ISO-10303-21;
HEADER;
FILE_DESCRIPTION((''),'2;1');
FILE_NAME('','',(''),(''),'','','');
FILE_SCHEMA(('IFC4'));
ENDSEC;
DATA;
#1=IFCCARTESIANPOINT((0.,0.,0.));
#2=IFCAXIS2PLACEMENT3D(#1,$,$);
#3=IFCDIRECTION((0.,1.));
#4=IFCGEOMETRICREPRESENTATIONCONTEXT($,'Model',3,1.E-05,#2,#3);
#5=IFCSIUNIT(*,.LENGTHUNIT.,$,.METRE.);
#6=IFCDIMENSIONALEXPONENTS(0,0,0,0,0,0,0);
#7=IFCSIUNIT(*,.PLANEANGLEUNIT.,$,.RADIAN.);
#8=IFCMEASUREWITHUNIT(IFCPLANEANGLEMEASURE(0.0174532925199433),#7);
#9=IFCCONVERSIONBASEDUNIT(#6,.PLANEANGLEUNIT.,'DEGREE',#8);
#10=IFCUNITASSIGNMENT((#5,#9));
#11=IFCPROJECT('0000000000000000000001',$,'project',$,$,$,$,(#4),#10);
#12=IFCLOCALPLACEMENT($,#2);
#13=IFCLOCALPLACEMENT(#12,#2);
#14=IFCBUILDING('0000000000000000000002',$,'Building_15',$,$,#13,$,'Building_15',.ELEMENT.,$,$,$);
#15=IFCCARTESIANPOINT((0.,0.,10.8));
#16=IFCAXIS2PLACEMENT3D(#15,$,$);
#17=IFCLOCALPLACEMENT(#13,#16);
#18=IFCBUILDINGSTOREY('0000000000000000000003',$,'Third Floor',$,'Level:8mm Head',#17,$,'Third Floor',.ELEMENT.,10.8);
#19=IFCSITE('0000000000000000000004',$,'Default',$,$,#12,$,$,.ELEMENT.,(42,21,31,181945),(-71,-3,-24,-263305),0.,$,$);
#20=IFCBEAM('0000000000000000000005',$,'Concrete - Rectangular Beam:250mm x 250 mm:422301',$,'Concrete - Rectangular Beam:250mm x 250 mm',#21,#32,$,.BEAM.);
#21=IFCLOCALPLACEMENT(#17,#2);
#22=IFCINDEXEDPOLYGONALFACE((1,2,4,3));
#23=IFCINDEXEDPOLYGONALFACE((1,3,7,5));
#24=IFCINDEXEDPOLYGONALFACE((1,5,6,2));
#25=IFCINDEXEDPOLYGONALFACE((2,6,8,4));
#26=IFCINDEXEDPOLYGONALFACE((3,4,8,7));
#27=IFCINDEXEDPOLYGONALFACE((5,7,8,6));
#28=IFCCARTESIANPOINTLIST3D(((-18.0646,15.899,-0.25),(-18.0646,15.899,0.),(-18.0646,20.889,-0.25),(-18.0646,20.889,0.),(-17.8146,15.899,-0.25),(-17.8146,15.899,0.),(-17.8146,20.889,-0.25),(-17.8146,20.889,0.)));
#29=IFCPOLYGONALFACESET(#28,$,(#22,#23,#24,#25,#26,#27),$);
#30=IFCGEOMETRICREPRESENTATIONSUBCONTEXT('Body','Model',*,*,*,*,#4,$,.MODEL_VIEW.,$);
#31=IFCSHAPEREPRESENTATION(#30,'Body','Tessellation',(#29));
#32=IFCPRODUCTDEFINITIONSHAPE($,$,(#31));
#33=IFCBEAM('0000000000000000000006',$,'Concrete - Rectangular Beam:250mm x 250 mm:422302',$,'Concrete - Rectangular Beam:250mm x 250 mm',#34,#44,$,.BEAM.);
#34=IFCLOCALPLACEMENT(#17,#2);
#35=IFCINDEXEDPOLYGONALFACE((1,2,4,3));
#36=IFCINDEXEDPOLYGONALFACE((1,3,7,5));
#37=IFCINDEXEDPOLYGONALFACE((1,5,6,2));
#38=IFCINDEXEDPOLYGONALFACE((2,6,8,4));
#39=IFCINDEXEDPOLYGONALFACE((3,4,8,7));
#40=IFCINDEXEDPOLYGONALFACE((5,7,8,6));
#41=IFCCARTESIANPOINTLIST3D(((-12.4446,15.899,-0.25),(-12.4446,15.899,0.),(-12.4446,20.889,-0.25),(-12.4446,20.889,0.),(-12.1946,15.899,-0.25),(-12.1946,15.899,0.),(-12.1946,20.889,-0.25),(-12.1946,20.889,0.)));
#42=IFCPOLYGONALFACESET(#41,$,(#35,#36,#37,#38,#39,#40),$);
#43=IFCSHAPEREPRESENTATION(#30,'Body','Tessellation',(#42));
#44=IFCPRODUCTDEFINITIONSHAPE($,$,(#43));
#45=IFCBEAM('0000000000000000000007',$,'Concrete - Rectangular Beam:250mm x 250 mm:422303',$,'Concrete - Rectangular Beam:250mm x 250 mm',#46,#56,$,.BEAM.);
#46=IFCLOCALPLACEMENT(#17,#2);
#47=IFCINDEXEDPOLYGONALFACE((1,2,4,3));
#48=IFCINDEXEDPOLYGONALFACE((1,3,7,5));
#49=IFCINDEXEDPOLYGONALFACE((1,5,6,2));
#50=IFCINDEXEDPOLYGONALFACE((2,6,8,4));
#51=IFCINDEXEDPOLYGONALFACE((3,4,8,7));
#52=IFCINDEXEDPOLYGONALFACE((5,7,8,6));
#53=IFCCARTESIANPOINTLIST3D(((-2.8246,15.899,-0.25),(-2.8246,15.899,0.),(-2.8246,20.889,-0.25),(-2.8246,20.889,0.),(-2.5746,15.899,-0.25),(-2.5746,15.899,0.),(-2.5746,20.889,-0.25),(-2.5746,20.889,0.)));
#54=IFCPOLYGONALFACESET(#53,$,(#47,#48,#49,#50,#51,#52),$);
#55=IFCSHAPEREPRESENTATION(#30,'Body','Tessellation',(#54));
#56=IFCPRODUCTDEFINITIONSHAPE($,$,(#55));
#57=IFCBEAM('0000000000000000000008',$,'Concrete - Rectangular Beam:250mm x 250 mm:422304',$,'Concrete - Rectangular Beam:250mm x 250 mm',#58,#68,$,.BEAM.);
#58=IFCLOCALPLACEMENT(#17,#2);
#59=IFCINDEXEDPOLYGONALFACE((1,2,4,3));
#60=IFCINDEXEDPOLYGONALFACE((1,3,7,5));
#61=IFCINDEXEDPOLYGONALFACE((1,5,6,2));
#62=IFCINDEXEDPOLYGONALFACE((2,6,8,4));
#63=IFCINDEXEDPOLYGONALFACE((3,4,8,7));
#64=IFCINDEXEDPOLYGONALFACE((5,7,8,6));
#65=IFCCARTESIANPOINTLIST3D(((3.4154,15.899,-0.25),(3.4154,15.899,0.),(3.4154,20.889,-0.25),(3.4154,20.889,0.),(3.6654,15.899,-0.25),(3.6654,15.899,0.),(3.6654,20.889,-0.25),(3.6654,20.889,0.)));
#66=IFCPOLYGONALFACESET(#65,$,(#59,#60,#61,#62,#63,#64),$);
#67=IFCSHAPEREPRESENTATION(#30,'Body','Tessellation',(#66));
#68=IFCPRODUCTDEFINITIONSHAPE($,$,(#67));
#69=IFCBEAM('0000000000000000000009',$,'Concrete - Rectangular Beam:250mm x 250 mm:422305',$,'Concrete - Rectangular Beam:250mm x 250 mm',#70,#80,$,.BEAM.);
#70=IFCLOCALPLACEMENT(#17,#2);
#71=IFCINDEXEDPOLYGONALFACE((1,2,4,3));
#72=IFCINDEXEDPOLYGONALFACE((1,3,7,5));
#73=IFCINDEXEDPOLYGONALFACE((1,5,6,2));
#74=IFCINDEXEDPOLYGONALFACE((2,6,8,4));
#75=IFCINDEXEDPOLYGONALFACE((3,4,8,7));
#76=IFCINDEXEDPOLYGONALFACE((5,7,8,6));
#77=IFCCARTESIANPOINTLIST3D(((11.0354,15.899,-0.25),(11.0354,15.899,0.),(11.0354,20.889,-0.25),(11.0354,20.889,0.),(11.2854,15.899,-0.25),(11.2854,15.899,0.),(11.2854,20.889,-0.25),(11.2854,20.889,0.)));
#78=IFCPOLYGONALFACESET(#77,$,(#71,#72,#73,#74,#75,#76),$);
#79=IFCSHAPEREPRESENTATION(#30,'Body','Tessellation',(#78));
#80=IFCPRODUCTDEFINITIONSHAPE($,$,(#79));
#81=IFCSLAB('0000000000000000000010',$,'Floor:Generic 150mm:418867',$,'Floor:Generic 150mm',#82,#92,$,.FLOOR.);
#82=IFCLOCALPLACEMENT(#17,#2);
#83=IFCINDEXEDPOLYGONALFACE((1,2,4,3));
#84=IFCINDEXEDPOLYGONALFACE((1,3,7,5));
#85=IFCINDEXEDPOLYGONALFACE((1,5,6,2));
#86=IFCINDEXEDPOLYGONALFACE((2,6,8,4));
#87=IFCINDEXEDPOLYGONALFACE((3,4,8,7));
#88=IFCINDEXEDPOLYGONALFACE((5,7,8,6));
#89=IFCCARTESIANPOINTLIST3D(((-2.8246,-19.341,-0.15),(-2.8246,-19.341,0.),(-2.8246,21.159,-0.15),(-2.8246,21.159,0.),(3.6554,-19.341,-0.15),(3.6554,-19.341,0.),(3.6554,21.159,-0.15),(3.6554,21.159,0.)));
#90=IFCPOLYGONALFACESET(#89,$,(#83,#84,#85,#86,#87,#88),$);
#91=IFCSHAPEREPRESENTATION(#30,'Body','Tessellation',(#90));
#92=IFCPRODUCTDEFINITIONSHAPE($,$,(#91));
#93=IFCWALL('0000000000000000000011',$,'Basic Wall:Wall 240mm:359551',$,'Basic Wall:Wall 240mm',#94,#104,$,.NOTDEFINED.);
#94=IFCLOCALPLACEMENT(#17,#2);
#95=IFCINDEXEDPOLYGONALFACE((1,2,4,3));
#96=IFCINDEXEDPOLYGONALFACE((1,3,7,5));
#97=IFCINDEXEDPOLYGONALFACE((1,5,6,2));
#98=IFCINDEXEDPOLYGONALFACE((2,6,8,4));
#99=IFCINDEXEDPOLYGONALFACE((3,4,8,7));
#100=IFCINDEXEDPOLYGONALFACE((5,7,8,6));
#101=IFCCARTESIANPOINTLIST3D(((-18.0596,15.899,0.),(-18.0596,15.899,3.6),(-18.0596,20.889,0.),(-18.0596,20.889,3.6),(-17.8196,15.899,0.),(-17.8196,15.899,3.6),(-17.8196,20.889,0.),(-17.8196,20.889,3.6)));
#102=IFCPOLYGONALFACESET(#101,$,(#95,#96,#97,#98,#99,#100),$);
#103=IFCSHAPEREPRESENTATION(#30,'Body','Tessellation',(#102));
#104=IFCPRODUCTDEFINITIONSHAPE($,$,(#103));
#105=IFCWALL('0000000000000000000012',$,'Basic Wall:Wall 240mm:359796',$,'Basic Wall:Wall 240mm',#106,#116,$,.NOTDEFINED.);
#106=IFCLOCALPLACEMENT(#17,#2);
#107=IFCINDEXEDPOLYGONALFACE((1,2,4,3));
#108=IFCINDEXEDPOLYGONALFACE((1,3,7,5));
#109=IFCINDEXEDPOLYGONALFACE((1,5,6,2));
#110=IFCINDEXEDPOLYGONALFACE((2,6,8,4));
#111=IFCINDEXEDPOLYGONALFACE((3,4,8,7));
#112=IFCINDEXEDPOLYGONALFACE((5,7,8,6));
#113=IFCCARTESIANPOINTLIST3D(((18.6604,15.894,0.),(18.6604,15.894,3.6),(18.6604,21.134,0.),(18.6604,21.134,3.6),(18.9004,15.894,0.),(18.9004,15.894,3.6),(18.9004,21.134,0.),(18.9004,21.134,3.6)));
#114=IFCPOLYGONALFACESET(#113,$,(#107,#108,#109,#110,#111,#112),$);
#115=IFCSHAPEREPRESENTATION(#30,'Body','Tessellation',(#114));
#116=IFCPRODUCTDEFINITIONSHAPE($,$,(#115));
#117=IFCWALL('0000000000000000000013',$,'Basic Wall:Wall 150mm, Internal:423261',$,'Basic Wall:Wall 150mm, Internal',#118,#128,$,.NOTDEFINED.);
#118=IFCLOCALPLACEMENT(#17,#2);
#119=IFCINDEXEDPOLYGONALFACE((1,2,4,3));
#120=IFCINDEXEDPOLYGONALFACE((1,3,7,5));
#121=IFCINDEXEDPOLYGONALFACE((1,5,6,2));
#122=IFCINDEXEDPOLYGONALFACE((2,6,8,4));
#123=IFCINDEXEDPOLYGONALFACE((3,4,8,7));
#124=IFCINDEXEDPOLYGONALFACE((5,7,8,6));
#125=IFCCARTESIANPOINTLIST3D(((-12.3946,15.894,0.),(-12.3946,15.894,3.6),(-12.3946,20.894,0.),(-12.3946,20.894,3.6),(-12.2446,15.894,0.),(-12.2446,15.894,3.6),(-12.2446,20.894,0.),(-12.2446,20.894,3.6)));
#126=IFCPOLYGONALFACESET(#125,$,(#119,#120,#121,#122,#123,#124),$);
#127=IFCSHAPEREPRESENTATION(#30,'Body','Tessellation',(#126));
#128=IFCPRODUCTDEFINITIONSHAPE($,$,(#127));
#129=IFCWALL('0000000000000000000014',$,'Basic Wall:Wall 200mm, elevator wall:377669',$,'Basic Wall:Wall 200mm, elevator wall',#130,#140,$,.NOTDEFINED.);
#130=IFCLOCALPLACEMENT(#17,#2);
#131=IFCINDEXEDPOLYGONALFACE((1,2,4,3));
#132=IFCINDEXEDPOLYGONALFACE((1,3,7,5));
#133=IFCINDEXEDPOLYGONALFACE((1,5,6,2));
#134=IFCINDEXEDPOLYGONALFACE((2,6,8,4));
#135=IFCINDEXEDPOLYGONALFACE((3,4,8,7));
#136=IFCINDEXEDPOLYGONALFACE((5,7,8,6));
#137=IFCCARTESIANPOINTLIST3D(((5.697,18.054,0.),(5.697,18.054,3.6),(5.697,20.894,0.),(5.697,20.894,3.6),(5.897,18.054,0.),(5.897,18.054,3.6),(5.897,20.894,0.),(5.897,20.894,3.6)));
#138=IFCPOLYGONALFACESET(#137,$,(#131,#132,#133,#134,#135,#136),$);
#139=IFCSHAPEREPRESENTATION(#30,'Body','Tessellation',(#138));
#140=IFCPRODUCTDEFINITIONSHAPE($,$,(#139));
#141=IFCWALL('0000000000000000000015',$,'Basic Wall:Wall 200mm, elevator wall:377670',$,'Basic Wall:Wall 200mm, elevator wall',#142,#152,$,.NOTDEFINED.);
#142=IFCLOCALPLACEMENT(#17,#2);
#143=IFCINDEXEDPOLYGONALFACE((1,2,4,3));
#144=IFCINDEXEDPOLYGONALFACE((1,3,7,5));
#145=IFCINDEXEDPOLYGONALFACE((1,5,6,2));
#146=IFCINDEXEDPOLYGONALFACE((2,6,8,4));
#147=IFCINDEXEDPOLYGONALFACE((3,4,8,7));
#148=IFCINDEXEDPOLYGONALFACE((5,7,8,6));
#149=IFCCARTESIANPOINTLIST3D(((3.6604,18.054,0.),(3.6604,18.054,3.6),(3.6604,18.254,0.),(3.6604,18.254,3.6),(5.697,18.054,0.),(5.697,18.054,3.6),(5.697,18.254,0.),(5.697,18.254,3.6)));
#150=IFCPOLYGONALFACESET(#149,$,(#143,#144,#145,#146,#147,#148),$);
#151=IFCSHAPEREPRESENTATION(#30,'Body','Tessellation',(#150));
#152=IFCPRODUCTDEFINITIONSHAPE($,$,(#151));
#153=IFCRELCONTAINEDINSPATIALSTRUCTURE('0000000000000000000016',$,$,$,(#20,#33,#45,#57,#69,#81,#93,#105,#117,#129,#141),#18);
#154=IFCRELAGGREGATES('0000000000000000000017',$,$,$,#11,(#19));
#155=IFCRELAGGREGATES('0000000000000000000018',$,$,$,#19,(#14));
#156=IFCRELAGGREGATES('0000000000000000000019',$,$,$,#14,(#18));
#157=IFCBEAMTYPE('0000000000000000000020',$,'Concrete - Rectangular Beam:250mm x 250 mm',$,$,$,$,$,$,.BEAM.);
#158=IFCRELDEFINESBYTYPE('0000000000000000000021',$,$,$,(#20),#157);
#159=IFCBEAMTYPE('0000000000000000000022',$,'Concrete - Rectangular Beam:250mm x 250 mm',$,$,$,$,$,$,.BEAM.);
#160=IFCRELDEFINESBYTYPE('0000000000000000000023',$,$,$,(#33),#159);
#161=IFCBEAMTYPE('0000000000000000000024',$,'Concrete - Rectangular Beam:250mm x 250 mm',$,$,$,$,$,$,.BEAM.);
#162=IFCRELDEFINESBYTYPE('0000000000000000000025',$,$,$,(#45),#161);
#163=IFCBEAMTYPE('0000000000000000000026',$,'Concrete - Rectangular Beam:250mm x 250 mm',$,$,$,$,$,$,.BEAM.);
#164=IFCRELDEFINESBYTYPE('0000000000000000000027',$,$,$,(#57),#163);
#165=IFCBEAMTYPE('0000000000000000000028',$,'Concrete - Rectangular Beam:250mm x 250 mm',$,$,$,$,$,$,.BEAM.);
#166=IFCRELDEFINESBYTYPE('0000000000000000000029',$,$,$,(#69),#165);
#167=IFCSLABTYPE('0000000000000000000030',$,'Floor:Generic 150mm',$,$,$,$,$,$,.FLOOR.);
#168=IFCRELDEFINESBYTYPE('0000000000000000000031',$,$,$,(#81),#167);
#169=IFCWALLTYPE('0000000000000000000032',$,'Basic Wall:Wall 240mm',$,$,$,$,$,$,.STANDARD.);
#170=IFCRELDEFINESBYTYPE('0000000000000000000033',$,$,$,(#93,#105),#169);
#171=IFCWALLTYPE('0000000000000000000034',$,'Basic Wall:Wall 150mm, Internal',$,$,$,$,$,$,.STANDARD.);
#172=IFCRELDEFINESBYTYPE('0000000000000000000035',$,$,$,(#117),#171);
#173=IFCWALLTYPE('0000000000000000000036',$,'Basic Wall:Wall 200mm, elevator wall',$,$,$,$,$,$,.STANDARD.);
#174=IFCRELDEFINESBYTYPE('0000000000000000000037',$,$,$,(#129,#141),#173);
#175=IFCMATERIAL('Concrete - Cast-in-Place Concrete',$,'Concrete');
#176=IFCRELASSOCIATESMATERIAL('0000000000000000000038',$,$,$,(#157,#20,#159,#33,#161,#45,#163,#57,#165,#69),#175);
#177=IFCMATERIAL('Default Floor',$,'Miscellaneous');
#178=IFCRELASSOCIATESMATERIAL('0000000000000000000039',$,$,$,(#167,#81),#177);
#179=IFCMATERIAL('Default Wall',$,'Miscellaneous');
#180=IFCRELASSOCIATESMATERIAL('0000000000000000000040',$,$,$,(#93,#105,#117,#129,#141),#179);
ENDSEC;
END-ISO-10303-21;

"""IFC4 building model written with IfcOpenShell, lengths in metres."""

from ifc_helpers import new_model, entity, si_unit, converted_unit, direction, frame, origin, place, context, subcontext, project, spatial, indexed_curve, outline, extrude, source, transform, mapped, material, type_object, type_shapes, element, save


model = new_model("IFC4")

# Units and contexts
model_context = context("Model", 3, precision=1e-05, world=origin(), true_north=direction((0.0, 1.0)))
body_context = subcontext(model_context, "Body", "Model", "MODEL_VIEW")
ifc_project = project(units=[si_unit("LENGTHUNIT", "METRE"), converted_unit("PLANEANGLEUNIT", "DEGREE", entity("IfcPlaneAngleMeasure", 0.0174532925199433), si_unit("PLANEANGLEUNIT", "RADIAN"), dimensions=[0, 0, 0, 0, 0, 0, 0])], contexts=[model_context])

# Site, building, storey
site_placement = place(None, origin())
site = spatial("IfcSite", under=ifc_project, at=site_placement, Name="Default", CompositionType="ELEMENT", RefLatitude=(42, 21, 31, 181945), RefLongitude=(-71, -3, -24, -263305), RefElevation=0.0)
building_placement = place(site_placement, origin())
building = spatial("IfcBuilding", under=site, at=building_placement, Name="Building_15", LongName="Building_15", CompositionType="ELEMENT")
storey_placement = place(building_placement, frame((0.0, 0.0, 10.8)))
storey = spatial("IfcBuildingStorey", under=building, at=storey_placement, Name="Third Floor", ObjectType="Level:8mm Head", LongName="Third Floor", CompositionType="ELEMENT", Elevation=10.8)

# Shared definitions
ifc_material_1 = material(Name="Concrete - Cast-in-Place Concrete", Category="Concrete")

# Beams
beam_type_1 = type_object("IfcBeamType", Name="Concrete - Rectangular Beam:250mm x 250 mm", PredefinedType="BEAM", material=ifc_material_1)
shared_shape_1 = source(origin(), body_context, "Body", "SweptSolid", [
    extrude(outline(indexed_curve([(-0.125, -0.125), (0.125, -0.125), (0.125, 0.125), (-0.125, 0.125), (-0.125, -0.125)], self_intersect=False)), frame((-17.9396, 15.899, 10.675), z_axis=(0.0, 1.0, 0.0), x_axis=(-1.0, 0.0, 0.0)), (0.0, 0.0, 1.0), 4.99),
])
type_shapes(beam_type_1, [shared_shape_1])
beam_1_placement = place(storey_placement, frame((0.0, 0.0, -10.8)))
element("IfcBeam", 1, at=beam_1_placement, inside=storey, type_object=beam_type_1, material=ifc_material_1, Name="Concrete - Rectangular Beam:250mm x 250 mm:422301", ObjectType="Concrete - Rectangular Beam:250mm x 250 mm", PredefinedType="BEAM", context=body_context, shape_type="MappedRepresentation", body=[
    mapped(shared_shape_1, transform((0.0, 0.0, 0.0), scale=1.0)),
])
beam_type_2 = type_object("IfcBeamType", Name="Concrete - Rectangular Beam:250mm x 250 mm", PredefinedType="BEAM", material=ifc_material_1)
shared_shape_2 = source(origin(), body_context, "Body", "SweptSolid", [
    extrude(outline(indexed_curve([(-0.125, -0.125), (0.125, -0.125), (0.125, 0.125), (-0.125, 0.125), (-0.125, -0.125)], self_intersect=False)), frame((-12.3196, 20.889, 10.675), z_axis=(0.0, -1.0, 0.0), x_axis=(-1.0, 0.0, 0.0)), (0.0, 0.0, 1.0), 4.99),
])
type_shapes(beam_type_2, [shared_shape_2])
beam_2_placement = place(storey_placement, frame((0.0, 0.0, -10.8)))
element("IfcBeam", 2, at=beam_2_placement, inside=storey, type_object=beam_type_2, material=ifc_material_1, Name="Concrete - Rectangular Beam:250mm x 250 mm:422302", ObjectType="Concrete - Rectangular Beam:250mm x 250 mm", PredefinedType="BEAM", context=body_context, shape_type="MappedRepresentation", body=[
    mapped(shared_shape_2, transform((0.0, 0.0, 0.0), scale=1.0)),
])
beam_type_3 = type_object("IfcBeamType", Name="Concrete - Rectangular Beam:250mm x 250 mm", PredefinedType="BEAM", material=ifc_material_1)
shared_shape_3 = source(origin(), body_context, "Body", "SweptSolid", [
    extrude(outline(indexed_curve([(-0.125, -0.125), (0.125, -0.125), (0.125, 0.125), (-0.125, 0.125), (-0.125, -0.125)], self_intersect=False)), frame((-2.6996, 20.889, 10.675), z_axis=(0.0, -1.0, 0.0), x_axis=(-1.0, 0.0, 0.0)), (0.0, 0.0, 1.0), 4.99),
])
type_shapes(beam_type_3, [shared_shape_3])
beam_3_placement = place(storey_placement, frame((0.0, 0.0, -10.8)))
element("IfcBeam", 3, at=beam_3_placement, inside=storey, type_object=beam_type_3, material=ifc_material_1, Name="Concrete - Rectangular Beam:250mm x 250 mm:422303", ObjectType="Concrete - Rectangular Beam:250mm x 250 mm", PredefinedType="BEAM", context=body_context, shape_type="MappedRepresentation", body=[
    mapped(shared_shape_3, transform((0.0, 0.0, 0.0), scale=1.0)),
])
beam_type_4 = type_object("IfcBeamType", Name="Concrete - Rectangular Beam:250mm x 250 mm", PredefinedType="BEAM", material=ifc_material_1)
shared_shape_4 = source(origin(), body_context, "Body", "SweptSolid", [
    extrude(outline(indexed_curve([(-0.125, -0.125), (0.125, -0.125), (0.125, 0.125), (-0.125, 0.125), (-0.125, -0.125)], self_intersect=False)), frame((3.5404, 20.889, 10.675), z_axis=(0.0, -1.0, 0.0), x_axis=(-1.0, 0.0, 0.0)), (0.0, 0.0, 1.0), 4.99),
])
type_shapes(beam_type_4, [shared_shape_4])
beam_4_placement = place(storey_placement, frame((0.0, 0.0, -10.8)))
element("IfcBeam", 4, at=beam_4_placement, inside=storey, type_object=beam_type_4, material=ifc_material_1, Name="Concrete - Rectangular Beam:250mm x 250 mm:422304", ObjectType="Concrete - Rectangular Beam:250mm x 250 mm", PredefinedType="BEAM", context=body_context, shape_type="MappedRepresentation", body=[
    mapped(shared_shape_4, transform((0.0, 0.0, 0.0), scale=1.0)),
])
beam_type_5 = type_object("IfcBeamType", Name="Concrete - Rectangular Beam:250mm x 250 mm", PredefinedType="BEAM", material=ifc_material_1)
shared_shape_5 = source(origin(), body_context, "Body", "SweptSolid", [
    extrude(outline(indexed_curve([(-0.125, -0.125), (0.125, -0.125), (0.125, 0.125), (-0.125, 0.125), (-0.125, -0.125)], self_intersect=False)), frame((11.1604, 20.889, 10.675), z_axis=(0.0, -1.0, 0.0), x_axis=(-1.0, 0.0, 0.0)), (0.0, 0.0, 1.0), 4.99),
])
type_shapes(beam_type_5, [shared_shape_5])
beam_5_placement = place(storey_placement, frame((0.0, 0.0, -10.8)))
element("IfcBeam", 5, at=beam_5_placement, inside=storey, type_object=beam_type_5, material=ifc_material_1, Name="Concrete - Rectangular Beam:250mm x 250 mm:422305", ObjectType="Concrete - Rectangular Beam:250mm x 250 mm", PredefinedType="BEAM", context=body_context, shape_type="MappedRepresentation", body=[
    mapped(shared_shape_5, transform((0.0, 0.0, 0.0), scale=1.0)),
])

# Shared definitions
ifc_material_2 = material(Name="Default Floor", Category="Miscellaneous")
slab_type = type_object("IfcSlabType", Name="Floor:Generic 150mm", PredefinedType="FLOOR", material=ifc_material_2)

# Slab
slab_1_placement = place(storey_placement, origin())
element("IfcSlab", 6, at=slab_1_placement, inside=storey, type_object=slab_type, material=ifc_material_2, Name="Floor:Generic 150mm:418867", ObjectType="Floor:Generic 150mm", PredefinedType="FLOOR", context=body_context, shape_type="SweptSolid", body=[
    extrude(outline(indexed_curve([(-20.25, -3.24), (20.25, -3.24), (20.25, 3.24), (-20.25, 3.24), (-20.25, -3.24)], self_intersect=False)), frame((0.4154, 0.909, 0.0), z_axis=(0.0, 0.0, -1.0), x_axis=(0.0, 1.0, 0.0)), (0.0, 0.0, 1.0), 0.15),
])

# Walls
ifc_material_3 = material(Name="Default Wall", Category="Miscellaneous")
wall_type_1 = type_object("IfcWallType", Name="Basic Wall:Wall 240mm", PredefinedType="STANDARD")
wall_1_placement = place(storey_placement, frame((-17.9396, 15.899, 0.0), z_axis=(0.0, 0.0, 1.0), x_axis=(0.0, 1.0, 0.0)))
element("IfcWall", 7, at=wall_1_placement, inside=storey, type_object=wall_type_1, material=ifc_material_3, Name="Basic Wall:Wall 240mm:359551", ObjectType="Basic Wall:Wall 240mm", PredefinedType="NOTDEFINED", context=body_context, shape_type="SweptSolid", body=[
    extrude(outline(indexed_curve([(4.99, 0.12), (0.0, 0.12), (0.0, -0.12), (4.99, -0.12), (4.99, 0.12)], self_intersect=False)), origin(), (0.0, 0.0, 1.0), 3.6),
])
wall_2_placement = place(storey_placement, frame((18.7804, 15.894, 0.0), z_axis=(0.0, 0.0, 1.0), x_axis=(0.0, 1.0, 0.0)))
element("IfcWall", 8, at=wall_2_placement, inside=storey, type_object=wall_type_1, material=ifc_material_3, Name="Basic Wall:Wall 240mm:359796", ObjectType="Basic Wall:Wall 240mm", PredefinedType="NOTDEFINED", context=body_context, shape_type="SweptSolid", body=[
    extrude(outline(indexed_curve([(5.24, 0.12), (0.0, 0.12), (0.0, -0.12), (5.24, -0.12), (5.24, 0.12)], self_intersect=False)), origin(), (0.0, 0.0, 1.0), 3.6),
])
wall_type_2 = type_object("IfcWallType", Name="Basic Wall:Wall 150mm, Internal", PredefinedType="STANDARD")
wall_3_placement = place(storey_placement, frame((-12.3196, 20.894, 0.0), z_axis=(0.0, 0.0, 1.0), x_axis=(0.0, -1.0, 0.0)))
element("IfcWall", 9, at=wall_3_placement, inside=storey, type_object=wall_type_2, material=ifc_material_3, Name="Basic Wall:Wall 150mm, Internal:423261", ObjectType="Basic Wall:Wall 150mm, Internal", PredefinedType="NOTDEFINED", context=body_context, shape_type="SweptSolid", body=[
    extrude(outline(indexed_curve([(5.0, 0.075), (0.0, 0.075), (0.0, -0.075), (5.0, -0.075), (5.0, 0.075)], self_intersect=False)), origin(), (0.0, 0.0, 1.0), 3.6),
])
wall_type_3 = type_object("IfcWallType", Name="Basic Wall:Wall 200mm, elevator wall", PredefinedType="STANDARD")
wall_4_placement = place(storey_placement, frame((5.797, 20.894, 0.0), z_axis=(0.0, 0.0, 1.0), x_axis=(0.0, -1.0, 0.0)))
element("IfcWall", 10, at=wall_4_placement, inside=storey, type_object=wall_type_3, material=ifc_material_3, Name="Basic Wall:Wall 200mm, elevator wall:377669", ObjectType="Basic Wall:Wall 200mm, elevator wall", PredefinedType="NOTDEFINED", context=body_context, shape_type="SweptSolid", body=[
    extrude(outline(indexed_curve([(2.84, 0.1), (0.0, 0.1), (0.0, -0.1), (2.84, -0.1), (2.84, 0.1)], self_intersect=False)), origin(), (0.0, 0.0, 1.0), 3.6),
])
wall_5_placement = place(storey_placement, frame((5.697, 18.154, 0.0), z_axis=(0.0, 0.0, 1.0), x_axis=(-1.0, 0.0, 0.0)))
element("IfcWall", 11, at=wall_5_placement, inside=storey, type_object=wall_type_3, material=ifc_material_3, Name="Basic Wall:Wall 200mm, elevator wall:377670", ObjectType="Basic Wall:Wall 200mm, elevator wall", PredefinedType="NOTDEFINED", context=body_context, shape_type="SweptSolid", body=[
    extrude(outline(indexed_curve([(2.0366, 0.1), (0.0, 0.1), (0.0, -0.1), (2.0366, -0.1), (2.0366, 0.1)], self_intersect=False)), origin(), (0.0, 0.0, 1.0), 3.6),
])

save(model, "model.ifc")
